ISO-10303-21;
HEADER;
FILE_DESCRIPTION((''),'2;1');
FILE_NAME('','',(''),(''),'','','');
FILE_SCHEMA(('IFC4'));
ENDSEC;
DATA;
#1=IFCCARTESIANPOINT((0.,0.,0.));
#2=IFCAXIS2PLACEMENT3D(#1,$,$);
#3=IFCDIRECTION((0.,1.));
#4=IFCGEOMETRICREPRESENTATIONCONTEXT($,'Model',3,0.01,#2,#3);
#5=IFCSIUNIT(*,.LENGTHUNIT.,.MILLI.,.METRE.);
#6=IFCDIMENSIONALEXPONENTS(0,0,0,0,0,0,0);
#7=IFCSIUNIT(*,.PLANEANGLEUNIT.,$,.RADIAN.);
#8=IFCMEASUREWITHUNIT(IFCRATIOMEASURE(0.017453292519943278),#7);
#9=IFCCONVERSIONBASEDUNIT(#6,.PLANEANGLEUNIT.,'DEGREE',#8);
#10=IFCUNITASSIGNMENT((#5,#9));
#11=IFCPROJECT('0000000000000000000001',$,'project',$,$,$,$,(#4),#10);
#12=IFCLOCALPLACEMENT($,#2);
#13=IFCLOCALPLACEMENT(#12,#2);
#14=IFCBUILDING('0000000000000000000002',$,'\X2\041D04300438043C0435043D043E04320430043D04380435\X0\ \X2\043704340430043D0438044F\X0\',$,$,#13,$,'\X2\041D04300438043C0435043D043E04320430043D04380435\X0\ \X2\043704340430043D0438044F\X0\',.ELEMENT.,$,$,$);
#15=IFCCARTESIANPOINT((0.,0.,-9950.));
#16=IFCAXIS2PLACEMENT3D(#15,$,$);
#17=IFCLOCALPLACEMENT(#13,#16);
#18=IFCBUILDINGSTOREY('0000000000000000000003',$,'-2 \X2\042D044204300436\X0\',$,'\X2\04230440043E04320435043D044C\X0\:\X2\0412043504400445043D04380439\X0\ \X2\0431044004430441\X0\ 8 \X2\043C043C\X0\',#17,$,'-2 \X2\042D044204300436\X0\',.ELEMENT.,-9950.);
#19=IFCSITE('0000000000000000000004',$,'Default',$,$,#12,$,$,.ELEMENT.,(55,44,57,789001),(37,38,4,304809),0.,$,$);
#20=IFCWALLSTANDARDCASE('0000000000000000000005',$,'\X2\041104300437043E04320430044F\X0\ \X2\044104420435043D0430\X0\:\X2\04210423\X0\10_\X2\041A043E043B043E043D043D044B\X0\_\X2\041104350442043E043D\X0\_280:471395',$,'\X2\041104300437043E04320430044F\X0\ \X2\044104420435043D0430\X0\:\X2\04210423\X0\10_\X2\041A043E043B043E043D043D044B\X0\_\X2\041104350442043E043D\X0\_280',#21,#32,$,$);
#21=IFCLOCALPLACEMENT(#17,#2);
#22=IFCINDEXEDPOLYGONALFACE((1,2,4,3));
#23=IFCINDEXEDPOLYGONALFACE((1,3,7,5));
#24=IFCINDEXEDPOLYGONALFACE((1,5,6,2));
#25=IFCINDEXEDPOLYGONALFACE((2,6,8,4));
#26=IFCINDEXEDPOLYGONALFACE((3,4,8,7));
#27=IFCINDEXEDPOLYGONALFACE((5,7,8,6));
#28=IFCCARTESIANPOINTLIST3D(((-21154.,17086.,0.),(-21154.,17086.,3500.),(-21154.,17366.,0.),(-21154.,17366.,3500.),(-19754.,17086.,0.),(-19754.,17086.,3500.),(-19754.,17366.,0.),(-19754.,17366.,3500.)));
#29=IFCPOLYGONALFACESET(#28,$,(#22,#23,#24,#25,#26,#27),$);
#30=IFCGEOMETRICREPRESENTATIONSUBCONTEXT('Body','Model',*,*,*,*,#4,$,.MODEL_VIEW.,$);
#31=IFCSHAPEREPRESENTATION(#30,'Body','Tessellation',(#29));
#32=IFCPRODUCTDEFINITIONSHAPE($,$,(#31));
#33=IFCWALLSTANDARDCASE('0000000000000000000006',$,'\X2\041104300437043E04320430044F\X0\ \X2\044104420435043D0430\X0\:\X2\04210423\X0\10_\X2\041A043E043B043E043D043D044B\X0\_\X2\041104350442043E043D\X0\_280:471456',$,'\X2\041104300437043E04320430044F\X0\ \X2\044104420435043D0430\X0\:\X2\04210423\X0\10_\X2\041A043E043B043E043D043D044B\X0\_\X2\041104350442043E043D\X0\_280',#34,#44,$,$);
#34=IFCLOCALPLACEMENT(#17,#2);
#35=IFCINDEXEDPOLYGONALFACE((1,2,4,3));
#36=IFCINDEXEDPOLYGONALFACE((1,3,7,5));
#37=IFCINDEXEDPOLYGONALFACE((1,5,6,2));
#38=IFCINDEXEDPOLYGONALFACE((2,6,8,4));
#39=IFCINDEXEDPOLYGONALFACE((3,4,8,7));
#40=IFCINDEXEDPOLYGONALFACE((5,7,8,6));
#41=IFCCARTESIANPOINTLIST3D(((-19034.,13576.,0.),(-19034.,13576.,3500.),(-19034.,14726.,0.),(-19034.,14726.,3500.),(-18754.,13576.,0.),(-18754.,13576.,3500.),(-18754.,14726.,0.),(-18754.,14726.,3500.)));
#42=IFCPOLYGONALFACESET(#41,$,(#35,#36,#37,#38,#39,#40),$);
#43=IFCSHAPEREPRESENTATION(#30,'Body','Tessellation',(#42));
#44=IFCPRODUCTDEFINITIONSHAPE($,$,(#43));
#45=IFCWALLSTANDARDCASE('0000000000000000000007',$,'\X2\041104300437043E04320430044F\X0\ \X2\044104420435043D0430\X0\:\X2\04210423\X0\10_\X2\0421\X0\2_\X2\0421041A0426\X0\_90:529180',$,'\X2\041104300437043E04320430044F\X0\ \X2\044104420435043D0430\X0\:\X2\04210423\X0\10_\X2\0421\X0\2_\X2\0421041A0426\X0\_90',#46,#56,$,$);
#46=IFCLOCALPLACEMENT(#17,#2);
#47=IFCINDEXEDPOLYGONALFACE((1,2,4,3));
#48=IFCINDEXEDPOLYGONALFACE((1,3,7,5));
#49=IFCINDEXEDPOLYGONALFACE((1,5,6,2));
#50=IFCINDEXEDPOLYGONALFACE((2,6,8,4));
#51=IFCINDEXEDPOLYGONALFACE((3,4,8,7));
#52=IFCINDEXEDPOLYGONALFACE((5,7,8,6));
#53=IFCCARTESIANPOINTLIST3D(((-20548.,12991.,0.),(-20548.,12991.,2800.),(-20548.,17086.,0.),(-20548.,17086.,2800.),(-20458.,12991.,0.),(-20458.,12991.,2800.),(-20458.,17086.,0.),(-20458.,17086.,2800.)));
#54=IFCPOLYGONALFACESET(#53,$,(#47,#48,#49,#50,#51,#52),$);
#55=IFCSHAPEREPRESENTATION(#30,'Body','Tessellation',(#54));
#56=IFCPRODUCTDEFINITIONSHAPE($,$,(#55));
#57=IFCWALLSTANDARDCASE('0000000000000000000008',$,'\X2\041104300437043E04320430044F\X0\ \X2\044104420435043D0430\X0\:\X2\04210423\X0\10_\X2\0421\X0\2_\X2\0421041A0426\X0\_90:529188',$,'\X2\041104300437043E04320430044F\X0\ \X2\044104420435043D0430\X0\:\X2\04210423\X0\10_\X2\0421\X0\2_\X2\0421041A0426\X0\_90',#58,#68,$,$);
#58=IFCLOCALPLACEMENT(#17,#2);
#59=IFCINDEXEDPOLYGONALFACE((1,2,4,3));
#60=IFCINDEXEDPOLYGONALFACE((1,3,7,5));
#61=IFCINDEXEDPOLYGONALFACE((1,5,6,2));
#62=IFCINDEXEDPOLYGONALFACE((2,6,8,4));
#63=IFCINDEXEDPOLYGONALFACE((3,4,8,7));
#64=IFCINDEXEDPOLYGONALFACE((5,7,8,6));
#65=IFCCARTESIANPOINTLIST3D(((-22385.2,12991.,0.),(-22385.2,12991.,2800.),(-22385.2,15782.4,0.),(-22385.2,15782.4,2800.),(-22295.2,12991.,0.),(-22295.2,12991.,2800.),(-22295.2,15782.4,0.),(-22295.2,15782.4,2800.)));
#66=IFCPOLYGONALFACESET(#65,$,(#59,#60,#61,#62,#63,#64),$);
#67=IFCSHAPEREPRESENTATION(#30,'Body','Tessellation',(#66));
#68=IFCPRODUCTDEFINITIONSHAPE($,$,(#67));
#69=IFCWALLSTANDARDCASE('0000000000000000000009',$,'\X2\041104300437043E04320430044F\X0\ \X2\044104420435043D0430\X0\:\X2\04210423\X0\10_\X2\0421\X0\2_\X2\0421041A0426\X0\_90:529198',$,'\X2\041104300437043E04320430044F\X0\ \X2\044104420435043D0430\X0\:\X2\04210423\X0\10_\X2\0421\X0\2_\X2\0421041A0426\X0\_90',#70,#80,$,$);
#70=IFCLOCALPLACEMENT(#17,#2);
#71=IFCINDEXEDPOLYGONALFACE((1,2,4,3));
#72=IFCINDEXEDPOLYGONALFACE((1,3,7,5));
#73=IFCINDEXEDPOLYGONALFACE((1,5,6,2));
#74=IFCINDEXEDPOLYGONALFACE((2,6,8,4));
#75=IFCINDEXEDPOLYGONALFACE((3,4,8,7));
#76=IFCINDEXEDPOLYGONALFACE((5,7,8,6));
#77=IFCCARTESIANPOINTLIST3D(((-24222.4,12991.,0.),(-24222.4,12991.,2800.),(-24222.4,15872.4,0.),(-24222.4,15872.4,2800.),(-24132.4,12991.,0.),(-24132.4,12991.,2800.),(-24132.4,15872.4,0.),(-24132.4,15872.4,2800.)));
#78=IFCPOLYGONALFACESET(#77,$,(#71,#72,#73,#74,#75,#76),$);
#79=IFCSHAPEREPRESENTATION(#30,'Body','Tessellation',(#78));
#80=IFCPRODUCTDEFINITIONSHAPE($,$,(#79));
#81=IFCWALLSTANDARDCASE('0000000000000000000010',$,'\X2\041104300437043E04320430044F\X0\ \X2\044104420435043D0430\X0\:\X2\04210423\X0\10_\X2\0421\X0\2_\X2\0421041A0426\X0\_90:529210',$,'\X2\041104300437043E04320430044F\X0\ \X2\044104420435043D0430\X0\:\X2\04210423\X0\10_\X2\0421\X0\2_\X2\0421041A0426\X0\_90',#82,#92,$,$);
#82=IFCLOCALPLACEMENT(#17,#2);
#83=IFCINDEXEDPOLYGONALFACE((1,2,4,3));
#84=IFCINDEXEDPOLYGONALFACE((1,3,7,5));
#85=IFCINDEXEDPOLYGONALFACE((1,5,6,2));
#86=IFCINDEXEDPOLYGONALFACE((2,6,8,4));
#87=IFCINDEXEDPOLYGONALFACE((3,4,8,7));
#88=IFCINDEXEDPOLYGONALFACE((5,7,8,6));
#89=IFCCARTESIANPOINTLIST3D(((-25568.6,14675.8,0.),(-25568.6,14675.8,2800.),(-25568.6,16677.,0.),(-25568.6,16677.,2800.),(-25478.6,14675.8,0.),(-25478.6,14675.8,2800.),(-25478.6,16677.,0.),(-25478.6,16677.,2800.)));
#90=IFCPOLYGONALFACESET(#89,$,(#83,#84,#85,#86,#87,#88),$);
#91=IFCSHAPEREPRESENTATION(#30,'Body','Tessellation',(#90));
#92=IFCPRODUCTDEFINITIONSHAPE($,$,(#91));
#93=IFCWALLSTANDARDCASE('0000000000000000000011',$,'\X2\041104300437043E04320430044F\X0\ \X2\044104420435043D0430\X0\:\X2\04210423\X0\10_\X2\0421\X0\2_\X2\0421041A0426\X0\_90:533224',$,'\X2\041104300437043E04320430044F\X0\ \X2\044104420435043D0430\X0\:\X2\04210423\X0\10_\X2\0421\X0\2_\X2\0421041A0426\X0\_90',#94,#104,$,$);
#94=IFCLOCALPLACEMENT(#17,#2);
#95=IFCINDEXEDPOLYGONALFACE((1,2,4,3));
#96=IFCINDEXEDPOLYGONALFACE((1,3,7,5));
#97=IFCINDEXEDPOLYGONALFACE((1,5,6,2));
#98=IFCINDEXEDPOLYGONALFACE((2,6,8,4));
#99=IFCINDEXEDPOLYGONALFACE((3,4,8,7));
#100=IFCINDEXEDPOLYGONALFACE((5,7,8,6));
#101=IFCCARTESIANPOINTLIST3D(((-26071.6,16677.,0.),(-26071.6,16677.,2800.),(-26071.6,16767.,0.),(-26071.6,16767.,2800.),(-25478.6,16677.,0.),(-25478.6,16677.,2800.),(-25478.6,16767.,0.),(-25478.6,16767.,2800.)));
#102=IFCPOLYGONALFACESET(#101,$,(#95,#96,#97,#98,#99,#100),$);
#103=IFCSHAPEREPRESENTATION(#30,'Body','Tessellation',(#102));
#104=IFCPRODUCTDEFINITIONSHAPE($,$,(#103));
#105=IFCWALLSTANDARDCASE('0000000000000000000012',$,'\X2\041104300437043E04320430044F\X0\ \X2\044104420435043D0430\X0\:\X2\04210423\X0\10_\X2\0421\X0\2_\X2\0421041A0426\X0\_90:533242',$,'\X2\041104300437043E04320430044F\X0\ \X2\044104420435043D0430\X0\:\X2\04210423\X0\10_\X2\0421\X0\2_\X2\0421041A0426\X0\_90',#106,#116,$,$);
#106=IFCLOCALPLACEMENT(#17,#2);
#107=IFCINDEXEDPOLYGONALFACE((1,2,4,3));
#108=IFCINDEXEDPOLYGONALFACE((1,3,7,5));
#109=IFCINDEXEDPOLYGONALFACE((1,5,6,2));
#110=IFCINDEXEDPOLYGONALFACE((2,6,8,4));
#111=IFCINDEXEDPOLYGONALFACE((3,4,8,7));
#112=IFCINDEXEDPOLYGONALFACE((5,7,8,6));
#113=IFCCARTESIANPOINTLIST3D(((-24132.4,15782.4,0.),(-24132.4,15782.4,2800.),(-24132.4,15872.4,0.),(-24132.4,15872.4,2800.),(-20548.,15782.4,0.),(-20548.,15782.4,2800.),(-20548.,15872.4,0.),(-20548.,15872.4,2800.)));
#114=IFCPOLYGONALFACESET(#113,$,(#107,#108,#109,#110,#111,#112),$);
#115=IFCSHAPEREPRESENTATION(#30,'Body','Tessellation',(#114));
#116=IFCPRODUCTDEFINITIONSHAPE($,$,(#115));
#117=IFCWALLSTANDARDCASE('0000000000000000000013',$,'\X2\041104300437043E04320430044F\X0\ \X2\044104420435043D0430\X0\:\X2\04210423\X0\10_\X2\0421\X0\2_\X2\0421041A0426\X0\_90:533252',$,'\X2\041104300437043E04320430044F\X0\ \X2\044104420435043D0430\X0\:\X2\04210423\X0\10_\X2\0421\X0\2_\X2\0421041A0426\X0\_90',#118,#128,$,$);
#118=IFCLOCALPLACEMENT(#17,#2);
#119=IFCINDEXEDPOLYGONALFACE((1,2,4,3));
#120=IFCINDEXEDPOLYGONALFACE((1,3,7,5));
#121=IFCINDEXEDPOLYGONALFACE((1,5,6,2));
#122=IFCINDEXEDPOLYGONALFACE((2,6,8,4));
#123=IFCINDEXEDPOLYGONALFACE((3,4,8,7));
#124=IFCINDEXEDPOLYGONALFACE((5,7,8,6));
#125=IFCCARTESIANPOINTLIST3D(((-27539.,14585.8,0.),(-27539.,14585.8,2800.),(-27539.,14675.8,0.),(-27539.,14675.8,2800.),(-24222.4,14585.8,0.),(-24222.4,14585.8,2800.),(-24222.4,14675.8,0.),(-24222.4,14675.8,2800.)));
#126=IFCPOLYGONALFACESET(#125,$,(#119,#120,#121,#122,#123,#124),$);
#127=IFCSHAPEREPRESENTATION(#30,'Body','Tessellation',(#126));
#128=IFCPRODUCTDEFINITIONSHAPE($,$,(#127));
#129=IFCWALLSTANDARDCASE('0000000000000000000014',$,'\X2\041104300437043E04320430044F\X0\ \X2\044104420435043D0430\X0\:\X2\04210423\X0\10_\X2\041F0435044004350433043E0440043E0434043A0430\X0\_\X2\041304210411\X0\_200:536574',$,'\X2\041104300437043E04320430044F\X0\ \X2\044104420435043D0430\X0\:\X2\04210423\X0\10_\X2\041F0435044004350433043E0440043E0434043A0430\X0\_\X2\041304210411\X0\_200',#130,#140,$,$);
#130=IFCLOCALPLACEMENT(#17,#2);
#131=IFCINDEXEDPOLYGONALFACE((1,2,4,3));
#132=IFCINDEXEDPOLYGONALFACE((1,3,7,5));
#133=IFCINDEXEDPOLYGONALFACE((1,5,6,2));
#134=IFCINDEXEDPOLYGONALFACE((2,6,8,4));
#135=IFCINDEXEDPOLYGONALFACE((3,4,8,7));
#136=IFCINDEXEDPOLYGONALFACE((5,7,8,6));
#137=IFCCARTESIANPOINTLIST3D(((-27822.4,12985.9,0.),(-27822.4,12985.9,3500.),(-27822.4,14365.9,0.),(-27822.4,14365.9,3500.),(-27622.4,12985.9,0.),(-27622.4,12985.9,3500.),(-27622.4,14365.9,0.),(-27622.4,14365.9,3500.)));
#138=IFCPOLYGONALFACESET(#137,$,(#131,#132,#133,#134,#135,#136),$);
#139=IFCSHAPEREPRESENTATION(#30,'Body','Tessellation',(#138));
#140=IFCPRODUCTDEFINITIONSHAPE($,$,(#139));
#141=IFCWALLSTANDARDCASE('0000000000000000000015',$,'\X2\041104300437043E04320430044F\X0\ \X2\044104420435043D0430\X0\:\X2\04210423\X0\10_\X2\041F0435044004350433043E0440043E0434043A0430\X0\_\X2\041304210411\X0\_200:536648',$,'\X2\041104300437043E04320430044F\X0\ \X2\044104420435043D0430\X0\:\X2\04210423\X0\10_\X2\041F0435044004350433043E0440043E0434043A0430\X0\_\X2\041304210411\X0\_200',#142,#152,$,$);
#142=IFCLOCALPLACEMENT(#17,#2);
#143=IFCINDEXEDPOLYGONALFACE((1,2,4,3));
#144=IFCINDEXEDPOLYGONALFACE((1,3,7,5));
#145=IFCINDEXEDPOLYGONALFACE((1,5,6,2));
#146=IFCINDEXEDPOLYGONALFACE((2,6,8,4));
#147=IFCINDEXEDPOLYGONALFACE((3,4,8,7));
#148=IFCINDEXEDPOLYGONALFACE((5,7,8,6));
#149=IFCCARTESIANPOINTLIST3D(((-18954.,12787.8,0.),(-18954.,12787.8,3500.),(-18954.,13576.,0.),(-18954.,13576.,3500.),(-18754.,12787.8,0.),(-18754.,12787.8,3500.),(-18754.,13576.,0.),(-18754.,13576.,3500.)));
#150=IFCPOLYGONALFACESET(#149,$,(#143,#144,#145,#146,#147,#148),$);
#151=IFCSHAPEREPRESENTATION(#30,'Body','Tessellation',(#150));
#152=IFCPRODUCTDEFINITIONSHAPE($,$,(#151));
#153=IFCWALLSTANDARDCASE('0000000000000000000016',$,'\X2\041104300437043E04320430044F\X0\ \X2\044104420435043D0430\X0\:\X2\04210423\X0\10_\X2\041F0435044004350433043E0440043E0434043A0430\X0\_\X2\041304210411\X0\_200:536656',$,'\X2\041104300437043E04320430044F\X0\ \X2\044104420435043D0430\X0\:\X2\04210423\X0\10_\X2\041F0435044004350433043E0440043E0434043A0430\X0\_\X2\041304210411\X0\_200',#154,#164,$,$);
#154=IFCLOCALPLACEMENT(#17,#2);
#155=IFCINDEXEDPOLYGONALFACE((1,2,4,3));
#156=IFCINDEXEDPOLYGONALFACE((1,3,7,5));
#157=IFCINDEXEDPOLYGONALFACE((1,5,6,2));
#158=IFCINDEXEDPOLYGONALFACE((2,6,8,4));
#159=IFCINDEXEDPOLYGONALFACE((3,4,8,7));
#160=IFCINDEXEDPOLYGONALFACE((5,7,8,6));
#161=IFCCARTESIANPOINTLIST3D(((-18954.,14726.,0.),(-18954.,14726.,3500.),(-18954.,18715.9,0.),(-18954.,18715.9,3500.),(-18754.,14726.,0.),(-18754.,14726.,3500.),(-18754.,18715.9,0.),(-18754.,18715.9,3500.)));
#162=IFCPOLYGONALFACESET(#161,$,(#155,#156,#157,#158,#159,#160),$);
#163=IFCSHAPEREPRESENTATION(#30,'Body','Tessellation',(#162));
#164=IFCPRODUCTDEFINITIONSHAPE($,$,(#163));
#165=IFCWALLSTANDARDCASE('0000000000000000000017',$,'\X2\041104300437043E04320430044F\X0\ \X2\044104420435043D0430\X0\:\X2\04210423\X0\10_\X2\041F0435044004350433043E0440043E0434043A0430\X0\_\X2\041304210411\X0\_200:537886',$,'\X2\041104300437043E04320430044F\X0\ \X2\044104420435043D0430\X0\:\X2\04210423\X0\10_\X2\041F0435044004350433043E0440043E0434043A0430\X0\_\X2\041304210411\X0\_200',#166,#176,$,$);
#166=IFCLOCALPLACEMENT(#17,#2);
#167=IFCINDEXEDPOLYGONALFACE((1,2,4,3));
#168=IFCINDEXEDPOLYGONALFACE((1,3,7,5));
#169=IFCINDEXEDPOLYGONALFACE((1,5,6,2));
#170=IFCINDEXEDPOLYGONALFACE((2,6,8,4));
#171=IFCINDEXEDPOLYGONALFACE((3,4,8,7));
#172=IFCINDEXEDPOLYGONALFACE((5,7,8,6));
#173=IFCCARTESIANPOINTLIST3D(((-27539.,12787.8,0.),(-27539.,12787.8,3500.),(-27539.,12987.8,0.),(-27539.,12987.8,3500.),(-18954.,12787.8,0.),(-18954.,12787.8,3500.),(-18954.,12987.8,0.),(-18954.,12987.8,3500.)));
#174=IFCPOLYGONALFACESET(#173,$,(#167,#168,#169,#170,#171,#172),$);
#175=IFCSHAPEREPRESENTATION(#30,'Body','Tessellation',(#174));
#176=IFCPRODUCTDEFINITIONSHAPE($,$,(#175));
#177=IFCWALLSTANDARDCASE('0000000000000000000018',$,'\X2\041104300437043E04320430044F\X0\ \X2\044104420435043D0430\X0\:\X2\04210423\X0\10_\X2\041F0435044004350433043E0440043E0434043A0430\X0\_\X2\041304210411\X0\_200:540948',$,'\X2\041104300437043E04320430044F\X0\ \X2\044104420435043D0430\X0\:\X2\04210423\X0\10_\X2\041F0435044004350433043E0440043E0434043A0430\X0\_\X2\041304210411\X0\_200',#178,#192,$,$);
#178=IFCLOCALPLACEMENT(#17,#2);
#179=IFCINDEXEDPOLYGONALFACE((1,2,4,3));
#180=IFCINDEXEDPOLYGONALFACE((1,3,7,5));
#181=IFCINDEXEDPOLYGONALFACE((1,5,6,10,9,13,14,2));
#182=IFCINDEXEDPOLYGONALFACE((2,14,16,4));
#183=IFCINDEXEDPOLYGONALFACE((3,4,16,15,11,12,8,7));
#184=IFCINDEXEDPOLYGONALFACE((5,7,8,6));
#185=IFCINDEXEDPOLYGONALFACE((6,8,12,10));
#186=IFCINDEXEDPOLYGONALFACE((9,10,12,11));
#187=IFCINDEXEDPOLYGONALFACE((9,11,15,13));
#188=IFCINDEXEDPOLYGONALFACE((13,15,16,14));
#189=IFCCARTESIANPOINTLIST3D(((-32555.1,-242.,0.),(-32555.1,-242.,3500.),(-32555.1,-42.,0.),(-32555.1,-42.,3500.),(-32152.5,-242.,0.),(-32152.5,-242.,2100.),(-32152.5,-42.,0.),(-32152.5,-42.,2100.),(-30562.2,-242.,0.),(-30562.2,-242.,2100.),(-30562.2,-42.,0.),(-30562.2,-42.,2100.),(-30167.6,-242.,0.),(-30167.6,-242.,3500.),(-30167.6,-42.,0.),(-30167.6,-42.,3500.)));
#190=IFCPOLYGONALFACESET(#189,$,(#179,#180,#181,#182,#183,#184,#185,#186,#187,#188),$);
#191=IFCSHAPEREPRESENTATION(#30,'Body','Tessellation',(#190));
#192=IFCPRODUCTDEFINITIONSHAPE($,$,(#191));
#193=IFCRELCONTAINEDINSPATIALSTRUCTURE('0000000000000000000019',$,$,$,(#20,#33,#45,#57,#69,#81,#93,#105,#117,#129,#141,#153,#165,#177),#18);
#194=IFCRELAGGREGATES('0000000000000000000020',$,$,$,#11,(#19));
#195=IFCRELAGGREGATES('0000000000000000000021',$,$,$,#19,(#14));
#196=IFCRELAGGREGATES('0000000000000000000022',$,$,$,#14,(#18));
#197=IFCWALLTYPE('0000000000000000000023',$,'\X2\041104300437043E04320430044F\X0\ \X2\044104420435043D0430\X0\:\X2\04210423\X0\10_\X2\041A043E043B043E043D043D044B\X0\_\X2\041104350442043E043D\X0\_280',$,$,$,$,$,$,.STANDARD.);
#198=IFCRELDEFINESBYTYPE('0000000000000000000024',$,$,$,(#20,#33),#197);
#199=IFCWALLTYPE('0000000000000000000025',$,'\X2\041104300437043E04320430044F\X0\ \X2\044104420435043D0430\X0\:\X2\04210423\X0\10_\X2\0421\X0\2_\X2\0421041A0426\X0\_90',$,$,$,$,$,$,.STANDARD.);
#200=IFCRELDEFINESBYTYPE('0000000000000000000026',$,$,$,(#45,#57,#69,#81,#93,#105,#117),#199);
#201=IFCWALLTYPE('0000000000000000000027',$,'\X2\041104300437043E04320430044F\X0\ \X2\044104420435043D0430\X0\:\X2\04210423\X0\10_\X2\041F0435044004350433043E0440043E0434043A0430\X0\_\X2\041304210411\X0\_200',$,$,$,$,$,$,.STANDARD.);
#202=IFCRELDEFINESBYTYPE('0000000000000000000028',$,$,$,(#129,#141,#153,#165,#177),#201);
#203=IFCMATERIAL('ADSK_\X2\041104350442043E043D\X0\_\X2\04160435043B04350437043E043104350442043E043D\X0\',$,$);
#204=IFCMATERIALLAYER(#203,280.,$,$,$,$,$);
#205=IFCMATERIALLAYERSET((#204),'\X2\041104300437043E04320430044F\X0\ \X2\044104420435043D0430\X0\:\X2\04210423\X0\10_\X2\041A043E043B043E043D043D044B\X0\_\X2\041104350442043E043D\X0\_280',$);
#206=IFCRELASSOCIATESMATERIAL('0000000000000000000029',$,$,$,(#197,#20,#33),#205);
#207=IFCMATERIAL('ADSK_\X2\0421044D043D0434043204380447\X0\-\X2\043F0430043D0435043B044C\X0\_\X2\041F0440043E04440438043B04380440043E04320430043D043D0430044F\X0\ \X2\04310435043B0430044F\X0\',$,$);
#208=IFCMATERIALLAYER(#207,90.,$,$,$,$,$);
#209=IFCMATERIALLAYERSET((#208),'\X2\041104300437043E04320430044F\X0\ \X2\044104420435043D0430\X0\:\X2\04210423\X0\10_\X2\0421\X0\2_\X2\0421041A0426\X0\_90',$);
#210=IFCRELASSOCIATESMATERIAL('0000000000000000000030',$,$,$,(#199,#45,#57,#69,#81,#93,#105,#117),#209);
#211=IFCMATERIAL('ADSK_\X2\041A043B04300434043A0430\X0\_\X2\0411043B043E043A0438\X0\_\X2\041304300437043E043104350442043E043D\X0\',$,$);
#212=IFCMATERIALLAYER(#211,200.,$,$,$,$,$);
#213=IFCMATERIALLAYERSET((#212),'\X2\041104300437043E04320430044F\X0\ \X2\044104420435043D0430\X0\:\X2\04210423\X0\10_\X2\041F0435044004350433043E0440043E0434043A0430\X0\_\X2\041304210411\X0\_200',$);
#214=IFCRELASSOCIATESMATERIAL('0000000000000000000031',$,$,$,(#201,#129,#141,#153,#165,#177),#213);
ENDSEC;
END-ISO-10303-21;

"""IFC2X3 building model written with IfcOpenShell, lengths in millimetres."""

from ifc_helpers import new_model, entity, si_unit, converted_unit, direction, frame, frame_2d, origin, place, context, subcontext, project, spatial, rectangle, extrude, material, layer, layer_set, layer_usage, type_object, element, save


model = new_model("IFC2X3")

# Units and contexts
model_context = context("Model", 3, precision=0.01, world=origin(), true_north=direction((0.0, 1.0)))
body_context = subcontext(model_context, "Body", "Model", "MODEL_VIEW")
ifc_project = project(units=[si_unit("LENGTHUNIT", "METRE", prefix="MILLI"), converted_unit("PLANEANGLEUNIT", "DEGREE", entity("IfcRatioMeasure", 0.017453292519943278), si_unit("PLANEANGLEUNIT", "RADIAN"), dimensions=[0, 0, 0, 0, 0, 0, 0])], contexts=[model_context])

# Site, building, storey
site_placement = place(None, origin())
site = spatial("IfcSite", under=ifc_project, at=site_placement, Name="Default", CompositionType="ELEMENT", RefLatitude=(55, 44, 57, 789001), RefLongitude=(37, 38, 4, 304809), RefElevation=0.0)
building_placement = place(site_placement, origin())
building = spatial("IfcBuilding", under=site, at=building_placement, Name="Наименование здания", LongName="Наименование здания", CompositionType="ELEMENT")
storey_placement = place(building_placement, frame((0.0, 0.0, -9950.0)))
storey = spatial("IfcBuildingStorey", under=building, at=storey_placement, Name="-2 Этаж", ObjectType="Уровень:Верхний брус 8 мм", LongName="-2 Этаж", CompositionType="ELEMENT", Elevation=-9950.0)

# Shared definitions
ifc_material_1 = material(Name="ADSK_Бетон_Железобетон")

# Walls
ifc_layer_1 = layer(ifc_material_1, 280.0)
ifc_layer_set_1 = layer_set([ifc_layer_1], Name="Базовая стена:СУ10_Колонны_Бетон_280")
ifc_layer_usage_1 = layer_usage(ifc_layer_set_1, "AXIS2", "NEGATIVE", 140.0)
wall_type_1 = type_object("IfcWallType", Name="Базовая стена:СУ10_Колонны_Бетон_280", PredefinedType="STANDARD", material=ifc_layer_set_1)
wall_1_placement = place(storey_placement, frame((-19754.0, 17226.0, 0.0), z_axis=(0.0, 0.0, 1.0), x_axis=(-1.0, 0.0, 0.0)))
element("IfcWallStandardCase", 1, at=wall_1_placement, inside=storey, type_object=wall_type_1, material=ifc_layer_usage_1, Name="Базовая стена:СУ10_Колонны_Бетон_280:471395", ObjectType="Базовая стена:СУ10_Колонны_Бетон_280", context=body_context, shape_type="SweptSolid", body=[
    extrude(rectangle(XDim=1399.9, YDim=280.0, at=frame_2d((700.0, 0.0), x_axis=(-1.0, 0.0))), origin(), (0.0, 0.0, 1.0), 3500.0),
])
wall_2_placement = place(storey_placement, frame((-18894.0, 13576.0, 0.0), z_axis=(0.0, 0.0, 1.0), x_axis=(0.0, 1.0, 0.0)))
element("IfcWallStandardCase", 2, at=wall_2_placement, inside=storey, type_object=wall_type_1, material=ifc_layer_usage_1, Name="Базовая стена:СУ10_Колонны_Бетон_280:471456", ObjectType="Базовая стена:СУ10_Колонны_Бетон_280", context=body_context, shape_type="SweptSolid", body=[
    extrude(rectangle(XDim=1150.0, YDim=280.0, at=frame_2d((575.0, 0.0), x_axis=(-1.0, 0.0))), origin(), (0.0, 0.0, 1.0), 3500.0),
])
ifc_material_2 = material(Name="ADSK_Сэндвич-панель_Профилированная белая")
ifc_layer_2 = layer(ifc_material_2, 90.0)
ifc_layer_set_2 = layer_set([ifc_layer_2], Name="Базовая стена:СУ10_С2_СКЦ_90")
ifc_layer_usage_2 = layer_usage(ifc_layer_set_2, "AXIS2", "NEGATIVE", 45.0)
wall_type_2 = type_object("IfcWallType", Name="Базовая стена:СУ10_С2_СКЦ_90", PredefinedType="STANDARD", material=ifc_layer_set_2)
wall_3_placement = place(storey_placement, frame((-20503.0, 17086.0, 0.0), z_axis=(0.0, 0.0, 1.0), x_axis=(0.0, -1.0, 0.0)))
element("IfcWallStandardCase", 3, at=wall_3_placement, inside=storey, type_object=wall_type_2, material=ifc_layer_usage_2, Name="Базовая стена:СУ10_С2_СКЦ_90:529180", ObjectType="Базовая стена:СУ10_С2_СКЦ_90", context=body_context, shape_type="SweptSolid", body=[
    extrude(rectangle(XDim=4094.9, YDim=90.0, at=frame_2d((2047.5, 0.0), x_axis=(-1.0, 0.0))), origin(), (0.0, 0.0, 1.0), 2800.0),
])
wall_4_placement = place(storey_placement, frame((-22340.2, 15782.4, 0.0), z_axis=(0.0, 0.0, 1.0), x_axis=(0.0, -1.0, 0.0)))
element("IfcWallStandardCase", 4, at=wall_4_placement, inside=storey, type_object=wall_type_2, material=ifc_layer_usage_2, Name="Базовая стена:СУ10_С2_СКЦ_90:529188", ObjectType="Базовая стена:СУ10_С2_СКЦ_90", context=body_context, shape_type="SweptSolid", body=[
    extrude(rectangle(XDim=2791.4, YDim=90.0, at=frame_2d((1395.7, 0.0), x_axis=(-1.0, 0.0))), origin(), (0.0, 0.0, 1.0), 2800.0),
])
wall_5_placement = place(storey_placement, frame((-24177.4, 15872.4, 0.0), z_axis=(0.0, 0.0, 1.0), x_axis=(0.0, -1.0, 0.0)))
element("IfcWallStandardCase", 5, at=wall_5_placement, inside=storey, type_object=wall_type_2, material=ifc_layer_usage_2, Name="Базовая стена:СУ10_С2_СКЦ_90:529198", ObjectType="Базовая стена:СУ10_С2_СКЦ_90", context=body_context, shape_type="SweptSolid", body=[
    extrude(rectangle(XDim=2881.4, YDim=90.0, at=frame_2d((1440.7, 0.0), x_axis=(-1.0, 0.0))), origin(), (0.0, 0.0, 1.0), 2800.0),
])
wall_6_placement = place(storey_placement, frame((-25523.6, 16677.0, 0.0), z_axis=(0.0, 0.0, 1.0), x_axis=(0.0, -1.0, 0.0)))
element("IfcWallStandardCase", 6, at=wall_6_placement, inside=storey, type_object=wall_type_2, material=ifc_layer_usage_2, Name="Базовая стена:СУ10_С2_СКЦ_90:529210", ObjectType="Базовая стена:СУ10_С2_СКЦ_90", context=body_context, shape_type="SweptSolid", body=[
    extrude(rectangle(XDim=2001.2, YDim=90.0, at=frame_2d((1000.6, 0.0), x_axis=(-1.0, 0.0))), origin(), (0.0, 0.0, 1.0), 2800.0),
])
wall_7_placement = place(storey_placement, frame((-25478.6, 16722.0, 0.0), z_axis=(0.0, 0.0, 1.0), x_axis=(-1.0, 0.0, 0.0)))
element("IfcWallStandardCase", 7, at=wall_7_placement, inside=storey, type_object=wall_type_2, material=ifc_layer_usage_2, Name="Базовая стена:СУ10_С2_СКЦ_90:533224", ObjectType="Базовая стена:СУ10_С2_СКЦ_90", context=body_context, shape_type="SweptSolid", body=[
    extrude(rectangle(XDim=593.0, YDim=90.0, at=frame_2d((296.5, 0.0), x_axis=(-1.0, 0.0))), origin(), (0.0, 0.0, 1.0), 2800.0),
])
wall_8_placement = place(storey_placement, frame((-20548.0, 15827.4, 0.0), z_axis=(0.0, 0.0, 1.0), x_axis=(-1.0, 0.0, 0.0)))
element("IfcWallStandardCase", 8, at=wall_8_placement, inside=storey, type_object=wall_type_2, material=ifc_layer_usage_2, Name="Базовая стена:СУ10_С2_СКЦ_90:533242", ObjectType="Базовая стена:СУ10_С2_СКЦ_90", context=body_context, shape_type="SweptSolid", body=[
    extrude(rectangle(XDim=3584.4, YDim=90.0, at=frame_2d((1792.2, 0.0), x_axis=(-1.0, 0.0))), origin(), (0.0, 0.0, 1.0), 2800.0),
])
wall_9_placement = place(storey_placement, frame((-24222.4, 14630.8, 0.0), z_axis=(0.0, 0.0, 1.0), x_axis=(-1.0, 0.0, 0.0)))
element("IfcWallStandardCase", 9, at=wall_9_placement, inside=storey, type_object=wall_type_2, material=ifc_layer_usage_2, Name="Базовая стена:СУ10_С2_СКЦ_90:533252", ObjectType="Базовая стена:СУ10_С2_СКЦ_90", context=body_context, shape_type="SweptSolid", body=[
    extrude(rectangle(XDim=3316.6, YDim=90.0, at=frame_2d((1658.3, 0.0), x_axis=(-1.0, 0.0))), origin(), (0.0, 0.0, 1.0), 2800.0),
])
ifc_material_3 = material(Name="ADSK_Кладка_Блоки_Газобетон")
ifc_layer_3 = layer(ifc_material_3, 200.0)
ifc_layer_set_3 = layer_set([ifc_layer_3], Name="Базовая стена:СУ10_Перегородка_ГСБ_200")
ifc_layer_usage_3 = layer_usage(ifc_layer_set_3, "AXIS2", "NEGATIVE", 100.0)
wall_type_3 = type_object("IfcWallType", Name="Базовая стена:СУ10_Перегородка_ГСБ_200", PredefinedType="STANDARD", material=ifc_layer_set_3)
wall_10_placement = place(storey_placement, frame((-27722.4, 12985.9, 0.0), z_axis=(0.0, 0.0, 1.0), x_axis=(0.0, 1.0, 0.0)))
element("IfcWallStandardCase", 10, at=wall_10_placement, inside=storey, type_object=wall_type_3, material=ifc_layer_usage_3, Name="Базовая стена:СУ10_Перегородка_ГСБ_200:536574", ObjectType="Базовая стена:СУ10_Перегородка_ГСБ_200", context=body_context, shape_type="SweptSolid", body=[
    extrude(rectangle(XDim=1380.0, YDim=200.0, at=frame_2d((690.0, 0.0), x_axis=(-1.0, 0.0))), origin(), (0.0, 0.0, 1.0), 3500.0),
])
wall_11_placement = place(storey_placement, frame((-18854.0, 12787.8, 0.0), z_axis=(0.0, 0.0, 1.0), x_axis=(0.0, 1.0, 0.0)))
element("IfcWallStandardCase", 11, at=wall_11_placement, inside=storey, type_object=wall_type_3, material=ifc_layer_usage_3, Name="Базовая стена:СУ10_Перегородка_ГСБ_200:536648", ObjectType="Базовая стена:СУ10_Перегородка_ГСБ_200", context=body_context, shape_type="SweptSolid", body=[
    extrude(rectangle(XDim=788.1, YDim=200.0, at=frame_2d((394.1, 0.0), x_axis=(-1.0, 0.0))), origin(), (0.0, 0.0, 1.0), 3500.0),
])
wall_12_placement = place(storey_placement, frame((-18854.0, 14726.0, 0.0), z_axis=(0.0, 0.0, 1.0), x_axis=(0.0, 1.0, 0.0)))
element("IfcWallStandardCase", 12, at=wall_12_placement, inside=storey, type_object=wall_type_3, material=ifc_layer_usage_3, Name="Базовая стена:СУ10_Перегородка_ГСБ_200:536656", ObjectType="Базовая стена:СУ10_Перегородка_ГСБ_200", context=body_context, shape_type="SweptSolid", body=[
    extrude(rectangle(XDim=3990.0, YDim=200.0, at=frame_2d((1995.0, 0.0), x_axis=(-1.0, 0.0))), origin(), (0.0, 0.0, 1.0), 3500.0),
])
wall_13_placement = place(storey_placement, frame((-18954.0, 12887.8, 0.0), z_axis=(0.0, 0.0, 1.0), x_axis=(-1.0, 0.0, 0.0)))
element("IfcWallStandardCase", 13, at=wall_13_placement, inside=storey, type_object=wall_type_3, material=ifc_layer_usage_3, Name="Базовая стена:СУ10_Перегородка_ГСБ_200:537886", ObjectType="Базовая стена:СУ10_Перегородка_ГСБ_200", context=body_context, shape_type="SweptSolid", body=[
    extrude(rectangle(XDim=8585.0, YDim=200.0, at=frame_2d((4292.5, 0.0), x_axis=(-1.0, 0.0))), origin(), (0.0, 0.0, 1.0), 3500.0),
])

# Wall, opening
wall_14_placement = place(storey_placement, frame((-30167.6, -142.0, 0.0), z_axis=(0.0, 0.0, 1.0), x_axis=(-1.0, 0.0, 0.0)))
wall_14 = element("IfcWallStandardCase", 14, at=wall_14_placement, inside=storey, type_object=wall_type_3, material=ifc_layer_usage_3, Name="Базовая стена:СУ10_Перегородка_ГСБ_200:540948", ObjectType="Базовая стена:СУ10_Перегородка_ГСБ_200", context=body_context, shape_type="SweptSolid", body=[
    extrude(rectangle(XDim=2387.5, YDim=200.0, at=frame_2d((1193.8, 0.0), x_axis=(1.0, 0.0))), origin(), (0.0, 0.0, 1.0), 3500.0),
])
opening_1_placement = place(wall_14_placement, origin())
element("IfcOpeningElement", 15, at=opening_1_placement, cuts=wall_14, ObjectType="Opening", context=body_context, shape_type="SweptSolid", body=[
    extrude(rectangle(XDim=2100.0, YDim=1590.3, at=frame_2d((0.0, 0.0), x_axis=(1.0, 0.0))), frame((1189.7, -100.0, 1050.0), z_axis=(0.0, 1.0, 0.0), x_axis=(0.0, 0.0, -1.0)), (0.0, 0.0, 1.0), 200.0),
])

save(model, "model.ifc")
